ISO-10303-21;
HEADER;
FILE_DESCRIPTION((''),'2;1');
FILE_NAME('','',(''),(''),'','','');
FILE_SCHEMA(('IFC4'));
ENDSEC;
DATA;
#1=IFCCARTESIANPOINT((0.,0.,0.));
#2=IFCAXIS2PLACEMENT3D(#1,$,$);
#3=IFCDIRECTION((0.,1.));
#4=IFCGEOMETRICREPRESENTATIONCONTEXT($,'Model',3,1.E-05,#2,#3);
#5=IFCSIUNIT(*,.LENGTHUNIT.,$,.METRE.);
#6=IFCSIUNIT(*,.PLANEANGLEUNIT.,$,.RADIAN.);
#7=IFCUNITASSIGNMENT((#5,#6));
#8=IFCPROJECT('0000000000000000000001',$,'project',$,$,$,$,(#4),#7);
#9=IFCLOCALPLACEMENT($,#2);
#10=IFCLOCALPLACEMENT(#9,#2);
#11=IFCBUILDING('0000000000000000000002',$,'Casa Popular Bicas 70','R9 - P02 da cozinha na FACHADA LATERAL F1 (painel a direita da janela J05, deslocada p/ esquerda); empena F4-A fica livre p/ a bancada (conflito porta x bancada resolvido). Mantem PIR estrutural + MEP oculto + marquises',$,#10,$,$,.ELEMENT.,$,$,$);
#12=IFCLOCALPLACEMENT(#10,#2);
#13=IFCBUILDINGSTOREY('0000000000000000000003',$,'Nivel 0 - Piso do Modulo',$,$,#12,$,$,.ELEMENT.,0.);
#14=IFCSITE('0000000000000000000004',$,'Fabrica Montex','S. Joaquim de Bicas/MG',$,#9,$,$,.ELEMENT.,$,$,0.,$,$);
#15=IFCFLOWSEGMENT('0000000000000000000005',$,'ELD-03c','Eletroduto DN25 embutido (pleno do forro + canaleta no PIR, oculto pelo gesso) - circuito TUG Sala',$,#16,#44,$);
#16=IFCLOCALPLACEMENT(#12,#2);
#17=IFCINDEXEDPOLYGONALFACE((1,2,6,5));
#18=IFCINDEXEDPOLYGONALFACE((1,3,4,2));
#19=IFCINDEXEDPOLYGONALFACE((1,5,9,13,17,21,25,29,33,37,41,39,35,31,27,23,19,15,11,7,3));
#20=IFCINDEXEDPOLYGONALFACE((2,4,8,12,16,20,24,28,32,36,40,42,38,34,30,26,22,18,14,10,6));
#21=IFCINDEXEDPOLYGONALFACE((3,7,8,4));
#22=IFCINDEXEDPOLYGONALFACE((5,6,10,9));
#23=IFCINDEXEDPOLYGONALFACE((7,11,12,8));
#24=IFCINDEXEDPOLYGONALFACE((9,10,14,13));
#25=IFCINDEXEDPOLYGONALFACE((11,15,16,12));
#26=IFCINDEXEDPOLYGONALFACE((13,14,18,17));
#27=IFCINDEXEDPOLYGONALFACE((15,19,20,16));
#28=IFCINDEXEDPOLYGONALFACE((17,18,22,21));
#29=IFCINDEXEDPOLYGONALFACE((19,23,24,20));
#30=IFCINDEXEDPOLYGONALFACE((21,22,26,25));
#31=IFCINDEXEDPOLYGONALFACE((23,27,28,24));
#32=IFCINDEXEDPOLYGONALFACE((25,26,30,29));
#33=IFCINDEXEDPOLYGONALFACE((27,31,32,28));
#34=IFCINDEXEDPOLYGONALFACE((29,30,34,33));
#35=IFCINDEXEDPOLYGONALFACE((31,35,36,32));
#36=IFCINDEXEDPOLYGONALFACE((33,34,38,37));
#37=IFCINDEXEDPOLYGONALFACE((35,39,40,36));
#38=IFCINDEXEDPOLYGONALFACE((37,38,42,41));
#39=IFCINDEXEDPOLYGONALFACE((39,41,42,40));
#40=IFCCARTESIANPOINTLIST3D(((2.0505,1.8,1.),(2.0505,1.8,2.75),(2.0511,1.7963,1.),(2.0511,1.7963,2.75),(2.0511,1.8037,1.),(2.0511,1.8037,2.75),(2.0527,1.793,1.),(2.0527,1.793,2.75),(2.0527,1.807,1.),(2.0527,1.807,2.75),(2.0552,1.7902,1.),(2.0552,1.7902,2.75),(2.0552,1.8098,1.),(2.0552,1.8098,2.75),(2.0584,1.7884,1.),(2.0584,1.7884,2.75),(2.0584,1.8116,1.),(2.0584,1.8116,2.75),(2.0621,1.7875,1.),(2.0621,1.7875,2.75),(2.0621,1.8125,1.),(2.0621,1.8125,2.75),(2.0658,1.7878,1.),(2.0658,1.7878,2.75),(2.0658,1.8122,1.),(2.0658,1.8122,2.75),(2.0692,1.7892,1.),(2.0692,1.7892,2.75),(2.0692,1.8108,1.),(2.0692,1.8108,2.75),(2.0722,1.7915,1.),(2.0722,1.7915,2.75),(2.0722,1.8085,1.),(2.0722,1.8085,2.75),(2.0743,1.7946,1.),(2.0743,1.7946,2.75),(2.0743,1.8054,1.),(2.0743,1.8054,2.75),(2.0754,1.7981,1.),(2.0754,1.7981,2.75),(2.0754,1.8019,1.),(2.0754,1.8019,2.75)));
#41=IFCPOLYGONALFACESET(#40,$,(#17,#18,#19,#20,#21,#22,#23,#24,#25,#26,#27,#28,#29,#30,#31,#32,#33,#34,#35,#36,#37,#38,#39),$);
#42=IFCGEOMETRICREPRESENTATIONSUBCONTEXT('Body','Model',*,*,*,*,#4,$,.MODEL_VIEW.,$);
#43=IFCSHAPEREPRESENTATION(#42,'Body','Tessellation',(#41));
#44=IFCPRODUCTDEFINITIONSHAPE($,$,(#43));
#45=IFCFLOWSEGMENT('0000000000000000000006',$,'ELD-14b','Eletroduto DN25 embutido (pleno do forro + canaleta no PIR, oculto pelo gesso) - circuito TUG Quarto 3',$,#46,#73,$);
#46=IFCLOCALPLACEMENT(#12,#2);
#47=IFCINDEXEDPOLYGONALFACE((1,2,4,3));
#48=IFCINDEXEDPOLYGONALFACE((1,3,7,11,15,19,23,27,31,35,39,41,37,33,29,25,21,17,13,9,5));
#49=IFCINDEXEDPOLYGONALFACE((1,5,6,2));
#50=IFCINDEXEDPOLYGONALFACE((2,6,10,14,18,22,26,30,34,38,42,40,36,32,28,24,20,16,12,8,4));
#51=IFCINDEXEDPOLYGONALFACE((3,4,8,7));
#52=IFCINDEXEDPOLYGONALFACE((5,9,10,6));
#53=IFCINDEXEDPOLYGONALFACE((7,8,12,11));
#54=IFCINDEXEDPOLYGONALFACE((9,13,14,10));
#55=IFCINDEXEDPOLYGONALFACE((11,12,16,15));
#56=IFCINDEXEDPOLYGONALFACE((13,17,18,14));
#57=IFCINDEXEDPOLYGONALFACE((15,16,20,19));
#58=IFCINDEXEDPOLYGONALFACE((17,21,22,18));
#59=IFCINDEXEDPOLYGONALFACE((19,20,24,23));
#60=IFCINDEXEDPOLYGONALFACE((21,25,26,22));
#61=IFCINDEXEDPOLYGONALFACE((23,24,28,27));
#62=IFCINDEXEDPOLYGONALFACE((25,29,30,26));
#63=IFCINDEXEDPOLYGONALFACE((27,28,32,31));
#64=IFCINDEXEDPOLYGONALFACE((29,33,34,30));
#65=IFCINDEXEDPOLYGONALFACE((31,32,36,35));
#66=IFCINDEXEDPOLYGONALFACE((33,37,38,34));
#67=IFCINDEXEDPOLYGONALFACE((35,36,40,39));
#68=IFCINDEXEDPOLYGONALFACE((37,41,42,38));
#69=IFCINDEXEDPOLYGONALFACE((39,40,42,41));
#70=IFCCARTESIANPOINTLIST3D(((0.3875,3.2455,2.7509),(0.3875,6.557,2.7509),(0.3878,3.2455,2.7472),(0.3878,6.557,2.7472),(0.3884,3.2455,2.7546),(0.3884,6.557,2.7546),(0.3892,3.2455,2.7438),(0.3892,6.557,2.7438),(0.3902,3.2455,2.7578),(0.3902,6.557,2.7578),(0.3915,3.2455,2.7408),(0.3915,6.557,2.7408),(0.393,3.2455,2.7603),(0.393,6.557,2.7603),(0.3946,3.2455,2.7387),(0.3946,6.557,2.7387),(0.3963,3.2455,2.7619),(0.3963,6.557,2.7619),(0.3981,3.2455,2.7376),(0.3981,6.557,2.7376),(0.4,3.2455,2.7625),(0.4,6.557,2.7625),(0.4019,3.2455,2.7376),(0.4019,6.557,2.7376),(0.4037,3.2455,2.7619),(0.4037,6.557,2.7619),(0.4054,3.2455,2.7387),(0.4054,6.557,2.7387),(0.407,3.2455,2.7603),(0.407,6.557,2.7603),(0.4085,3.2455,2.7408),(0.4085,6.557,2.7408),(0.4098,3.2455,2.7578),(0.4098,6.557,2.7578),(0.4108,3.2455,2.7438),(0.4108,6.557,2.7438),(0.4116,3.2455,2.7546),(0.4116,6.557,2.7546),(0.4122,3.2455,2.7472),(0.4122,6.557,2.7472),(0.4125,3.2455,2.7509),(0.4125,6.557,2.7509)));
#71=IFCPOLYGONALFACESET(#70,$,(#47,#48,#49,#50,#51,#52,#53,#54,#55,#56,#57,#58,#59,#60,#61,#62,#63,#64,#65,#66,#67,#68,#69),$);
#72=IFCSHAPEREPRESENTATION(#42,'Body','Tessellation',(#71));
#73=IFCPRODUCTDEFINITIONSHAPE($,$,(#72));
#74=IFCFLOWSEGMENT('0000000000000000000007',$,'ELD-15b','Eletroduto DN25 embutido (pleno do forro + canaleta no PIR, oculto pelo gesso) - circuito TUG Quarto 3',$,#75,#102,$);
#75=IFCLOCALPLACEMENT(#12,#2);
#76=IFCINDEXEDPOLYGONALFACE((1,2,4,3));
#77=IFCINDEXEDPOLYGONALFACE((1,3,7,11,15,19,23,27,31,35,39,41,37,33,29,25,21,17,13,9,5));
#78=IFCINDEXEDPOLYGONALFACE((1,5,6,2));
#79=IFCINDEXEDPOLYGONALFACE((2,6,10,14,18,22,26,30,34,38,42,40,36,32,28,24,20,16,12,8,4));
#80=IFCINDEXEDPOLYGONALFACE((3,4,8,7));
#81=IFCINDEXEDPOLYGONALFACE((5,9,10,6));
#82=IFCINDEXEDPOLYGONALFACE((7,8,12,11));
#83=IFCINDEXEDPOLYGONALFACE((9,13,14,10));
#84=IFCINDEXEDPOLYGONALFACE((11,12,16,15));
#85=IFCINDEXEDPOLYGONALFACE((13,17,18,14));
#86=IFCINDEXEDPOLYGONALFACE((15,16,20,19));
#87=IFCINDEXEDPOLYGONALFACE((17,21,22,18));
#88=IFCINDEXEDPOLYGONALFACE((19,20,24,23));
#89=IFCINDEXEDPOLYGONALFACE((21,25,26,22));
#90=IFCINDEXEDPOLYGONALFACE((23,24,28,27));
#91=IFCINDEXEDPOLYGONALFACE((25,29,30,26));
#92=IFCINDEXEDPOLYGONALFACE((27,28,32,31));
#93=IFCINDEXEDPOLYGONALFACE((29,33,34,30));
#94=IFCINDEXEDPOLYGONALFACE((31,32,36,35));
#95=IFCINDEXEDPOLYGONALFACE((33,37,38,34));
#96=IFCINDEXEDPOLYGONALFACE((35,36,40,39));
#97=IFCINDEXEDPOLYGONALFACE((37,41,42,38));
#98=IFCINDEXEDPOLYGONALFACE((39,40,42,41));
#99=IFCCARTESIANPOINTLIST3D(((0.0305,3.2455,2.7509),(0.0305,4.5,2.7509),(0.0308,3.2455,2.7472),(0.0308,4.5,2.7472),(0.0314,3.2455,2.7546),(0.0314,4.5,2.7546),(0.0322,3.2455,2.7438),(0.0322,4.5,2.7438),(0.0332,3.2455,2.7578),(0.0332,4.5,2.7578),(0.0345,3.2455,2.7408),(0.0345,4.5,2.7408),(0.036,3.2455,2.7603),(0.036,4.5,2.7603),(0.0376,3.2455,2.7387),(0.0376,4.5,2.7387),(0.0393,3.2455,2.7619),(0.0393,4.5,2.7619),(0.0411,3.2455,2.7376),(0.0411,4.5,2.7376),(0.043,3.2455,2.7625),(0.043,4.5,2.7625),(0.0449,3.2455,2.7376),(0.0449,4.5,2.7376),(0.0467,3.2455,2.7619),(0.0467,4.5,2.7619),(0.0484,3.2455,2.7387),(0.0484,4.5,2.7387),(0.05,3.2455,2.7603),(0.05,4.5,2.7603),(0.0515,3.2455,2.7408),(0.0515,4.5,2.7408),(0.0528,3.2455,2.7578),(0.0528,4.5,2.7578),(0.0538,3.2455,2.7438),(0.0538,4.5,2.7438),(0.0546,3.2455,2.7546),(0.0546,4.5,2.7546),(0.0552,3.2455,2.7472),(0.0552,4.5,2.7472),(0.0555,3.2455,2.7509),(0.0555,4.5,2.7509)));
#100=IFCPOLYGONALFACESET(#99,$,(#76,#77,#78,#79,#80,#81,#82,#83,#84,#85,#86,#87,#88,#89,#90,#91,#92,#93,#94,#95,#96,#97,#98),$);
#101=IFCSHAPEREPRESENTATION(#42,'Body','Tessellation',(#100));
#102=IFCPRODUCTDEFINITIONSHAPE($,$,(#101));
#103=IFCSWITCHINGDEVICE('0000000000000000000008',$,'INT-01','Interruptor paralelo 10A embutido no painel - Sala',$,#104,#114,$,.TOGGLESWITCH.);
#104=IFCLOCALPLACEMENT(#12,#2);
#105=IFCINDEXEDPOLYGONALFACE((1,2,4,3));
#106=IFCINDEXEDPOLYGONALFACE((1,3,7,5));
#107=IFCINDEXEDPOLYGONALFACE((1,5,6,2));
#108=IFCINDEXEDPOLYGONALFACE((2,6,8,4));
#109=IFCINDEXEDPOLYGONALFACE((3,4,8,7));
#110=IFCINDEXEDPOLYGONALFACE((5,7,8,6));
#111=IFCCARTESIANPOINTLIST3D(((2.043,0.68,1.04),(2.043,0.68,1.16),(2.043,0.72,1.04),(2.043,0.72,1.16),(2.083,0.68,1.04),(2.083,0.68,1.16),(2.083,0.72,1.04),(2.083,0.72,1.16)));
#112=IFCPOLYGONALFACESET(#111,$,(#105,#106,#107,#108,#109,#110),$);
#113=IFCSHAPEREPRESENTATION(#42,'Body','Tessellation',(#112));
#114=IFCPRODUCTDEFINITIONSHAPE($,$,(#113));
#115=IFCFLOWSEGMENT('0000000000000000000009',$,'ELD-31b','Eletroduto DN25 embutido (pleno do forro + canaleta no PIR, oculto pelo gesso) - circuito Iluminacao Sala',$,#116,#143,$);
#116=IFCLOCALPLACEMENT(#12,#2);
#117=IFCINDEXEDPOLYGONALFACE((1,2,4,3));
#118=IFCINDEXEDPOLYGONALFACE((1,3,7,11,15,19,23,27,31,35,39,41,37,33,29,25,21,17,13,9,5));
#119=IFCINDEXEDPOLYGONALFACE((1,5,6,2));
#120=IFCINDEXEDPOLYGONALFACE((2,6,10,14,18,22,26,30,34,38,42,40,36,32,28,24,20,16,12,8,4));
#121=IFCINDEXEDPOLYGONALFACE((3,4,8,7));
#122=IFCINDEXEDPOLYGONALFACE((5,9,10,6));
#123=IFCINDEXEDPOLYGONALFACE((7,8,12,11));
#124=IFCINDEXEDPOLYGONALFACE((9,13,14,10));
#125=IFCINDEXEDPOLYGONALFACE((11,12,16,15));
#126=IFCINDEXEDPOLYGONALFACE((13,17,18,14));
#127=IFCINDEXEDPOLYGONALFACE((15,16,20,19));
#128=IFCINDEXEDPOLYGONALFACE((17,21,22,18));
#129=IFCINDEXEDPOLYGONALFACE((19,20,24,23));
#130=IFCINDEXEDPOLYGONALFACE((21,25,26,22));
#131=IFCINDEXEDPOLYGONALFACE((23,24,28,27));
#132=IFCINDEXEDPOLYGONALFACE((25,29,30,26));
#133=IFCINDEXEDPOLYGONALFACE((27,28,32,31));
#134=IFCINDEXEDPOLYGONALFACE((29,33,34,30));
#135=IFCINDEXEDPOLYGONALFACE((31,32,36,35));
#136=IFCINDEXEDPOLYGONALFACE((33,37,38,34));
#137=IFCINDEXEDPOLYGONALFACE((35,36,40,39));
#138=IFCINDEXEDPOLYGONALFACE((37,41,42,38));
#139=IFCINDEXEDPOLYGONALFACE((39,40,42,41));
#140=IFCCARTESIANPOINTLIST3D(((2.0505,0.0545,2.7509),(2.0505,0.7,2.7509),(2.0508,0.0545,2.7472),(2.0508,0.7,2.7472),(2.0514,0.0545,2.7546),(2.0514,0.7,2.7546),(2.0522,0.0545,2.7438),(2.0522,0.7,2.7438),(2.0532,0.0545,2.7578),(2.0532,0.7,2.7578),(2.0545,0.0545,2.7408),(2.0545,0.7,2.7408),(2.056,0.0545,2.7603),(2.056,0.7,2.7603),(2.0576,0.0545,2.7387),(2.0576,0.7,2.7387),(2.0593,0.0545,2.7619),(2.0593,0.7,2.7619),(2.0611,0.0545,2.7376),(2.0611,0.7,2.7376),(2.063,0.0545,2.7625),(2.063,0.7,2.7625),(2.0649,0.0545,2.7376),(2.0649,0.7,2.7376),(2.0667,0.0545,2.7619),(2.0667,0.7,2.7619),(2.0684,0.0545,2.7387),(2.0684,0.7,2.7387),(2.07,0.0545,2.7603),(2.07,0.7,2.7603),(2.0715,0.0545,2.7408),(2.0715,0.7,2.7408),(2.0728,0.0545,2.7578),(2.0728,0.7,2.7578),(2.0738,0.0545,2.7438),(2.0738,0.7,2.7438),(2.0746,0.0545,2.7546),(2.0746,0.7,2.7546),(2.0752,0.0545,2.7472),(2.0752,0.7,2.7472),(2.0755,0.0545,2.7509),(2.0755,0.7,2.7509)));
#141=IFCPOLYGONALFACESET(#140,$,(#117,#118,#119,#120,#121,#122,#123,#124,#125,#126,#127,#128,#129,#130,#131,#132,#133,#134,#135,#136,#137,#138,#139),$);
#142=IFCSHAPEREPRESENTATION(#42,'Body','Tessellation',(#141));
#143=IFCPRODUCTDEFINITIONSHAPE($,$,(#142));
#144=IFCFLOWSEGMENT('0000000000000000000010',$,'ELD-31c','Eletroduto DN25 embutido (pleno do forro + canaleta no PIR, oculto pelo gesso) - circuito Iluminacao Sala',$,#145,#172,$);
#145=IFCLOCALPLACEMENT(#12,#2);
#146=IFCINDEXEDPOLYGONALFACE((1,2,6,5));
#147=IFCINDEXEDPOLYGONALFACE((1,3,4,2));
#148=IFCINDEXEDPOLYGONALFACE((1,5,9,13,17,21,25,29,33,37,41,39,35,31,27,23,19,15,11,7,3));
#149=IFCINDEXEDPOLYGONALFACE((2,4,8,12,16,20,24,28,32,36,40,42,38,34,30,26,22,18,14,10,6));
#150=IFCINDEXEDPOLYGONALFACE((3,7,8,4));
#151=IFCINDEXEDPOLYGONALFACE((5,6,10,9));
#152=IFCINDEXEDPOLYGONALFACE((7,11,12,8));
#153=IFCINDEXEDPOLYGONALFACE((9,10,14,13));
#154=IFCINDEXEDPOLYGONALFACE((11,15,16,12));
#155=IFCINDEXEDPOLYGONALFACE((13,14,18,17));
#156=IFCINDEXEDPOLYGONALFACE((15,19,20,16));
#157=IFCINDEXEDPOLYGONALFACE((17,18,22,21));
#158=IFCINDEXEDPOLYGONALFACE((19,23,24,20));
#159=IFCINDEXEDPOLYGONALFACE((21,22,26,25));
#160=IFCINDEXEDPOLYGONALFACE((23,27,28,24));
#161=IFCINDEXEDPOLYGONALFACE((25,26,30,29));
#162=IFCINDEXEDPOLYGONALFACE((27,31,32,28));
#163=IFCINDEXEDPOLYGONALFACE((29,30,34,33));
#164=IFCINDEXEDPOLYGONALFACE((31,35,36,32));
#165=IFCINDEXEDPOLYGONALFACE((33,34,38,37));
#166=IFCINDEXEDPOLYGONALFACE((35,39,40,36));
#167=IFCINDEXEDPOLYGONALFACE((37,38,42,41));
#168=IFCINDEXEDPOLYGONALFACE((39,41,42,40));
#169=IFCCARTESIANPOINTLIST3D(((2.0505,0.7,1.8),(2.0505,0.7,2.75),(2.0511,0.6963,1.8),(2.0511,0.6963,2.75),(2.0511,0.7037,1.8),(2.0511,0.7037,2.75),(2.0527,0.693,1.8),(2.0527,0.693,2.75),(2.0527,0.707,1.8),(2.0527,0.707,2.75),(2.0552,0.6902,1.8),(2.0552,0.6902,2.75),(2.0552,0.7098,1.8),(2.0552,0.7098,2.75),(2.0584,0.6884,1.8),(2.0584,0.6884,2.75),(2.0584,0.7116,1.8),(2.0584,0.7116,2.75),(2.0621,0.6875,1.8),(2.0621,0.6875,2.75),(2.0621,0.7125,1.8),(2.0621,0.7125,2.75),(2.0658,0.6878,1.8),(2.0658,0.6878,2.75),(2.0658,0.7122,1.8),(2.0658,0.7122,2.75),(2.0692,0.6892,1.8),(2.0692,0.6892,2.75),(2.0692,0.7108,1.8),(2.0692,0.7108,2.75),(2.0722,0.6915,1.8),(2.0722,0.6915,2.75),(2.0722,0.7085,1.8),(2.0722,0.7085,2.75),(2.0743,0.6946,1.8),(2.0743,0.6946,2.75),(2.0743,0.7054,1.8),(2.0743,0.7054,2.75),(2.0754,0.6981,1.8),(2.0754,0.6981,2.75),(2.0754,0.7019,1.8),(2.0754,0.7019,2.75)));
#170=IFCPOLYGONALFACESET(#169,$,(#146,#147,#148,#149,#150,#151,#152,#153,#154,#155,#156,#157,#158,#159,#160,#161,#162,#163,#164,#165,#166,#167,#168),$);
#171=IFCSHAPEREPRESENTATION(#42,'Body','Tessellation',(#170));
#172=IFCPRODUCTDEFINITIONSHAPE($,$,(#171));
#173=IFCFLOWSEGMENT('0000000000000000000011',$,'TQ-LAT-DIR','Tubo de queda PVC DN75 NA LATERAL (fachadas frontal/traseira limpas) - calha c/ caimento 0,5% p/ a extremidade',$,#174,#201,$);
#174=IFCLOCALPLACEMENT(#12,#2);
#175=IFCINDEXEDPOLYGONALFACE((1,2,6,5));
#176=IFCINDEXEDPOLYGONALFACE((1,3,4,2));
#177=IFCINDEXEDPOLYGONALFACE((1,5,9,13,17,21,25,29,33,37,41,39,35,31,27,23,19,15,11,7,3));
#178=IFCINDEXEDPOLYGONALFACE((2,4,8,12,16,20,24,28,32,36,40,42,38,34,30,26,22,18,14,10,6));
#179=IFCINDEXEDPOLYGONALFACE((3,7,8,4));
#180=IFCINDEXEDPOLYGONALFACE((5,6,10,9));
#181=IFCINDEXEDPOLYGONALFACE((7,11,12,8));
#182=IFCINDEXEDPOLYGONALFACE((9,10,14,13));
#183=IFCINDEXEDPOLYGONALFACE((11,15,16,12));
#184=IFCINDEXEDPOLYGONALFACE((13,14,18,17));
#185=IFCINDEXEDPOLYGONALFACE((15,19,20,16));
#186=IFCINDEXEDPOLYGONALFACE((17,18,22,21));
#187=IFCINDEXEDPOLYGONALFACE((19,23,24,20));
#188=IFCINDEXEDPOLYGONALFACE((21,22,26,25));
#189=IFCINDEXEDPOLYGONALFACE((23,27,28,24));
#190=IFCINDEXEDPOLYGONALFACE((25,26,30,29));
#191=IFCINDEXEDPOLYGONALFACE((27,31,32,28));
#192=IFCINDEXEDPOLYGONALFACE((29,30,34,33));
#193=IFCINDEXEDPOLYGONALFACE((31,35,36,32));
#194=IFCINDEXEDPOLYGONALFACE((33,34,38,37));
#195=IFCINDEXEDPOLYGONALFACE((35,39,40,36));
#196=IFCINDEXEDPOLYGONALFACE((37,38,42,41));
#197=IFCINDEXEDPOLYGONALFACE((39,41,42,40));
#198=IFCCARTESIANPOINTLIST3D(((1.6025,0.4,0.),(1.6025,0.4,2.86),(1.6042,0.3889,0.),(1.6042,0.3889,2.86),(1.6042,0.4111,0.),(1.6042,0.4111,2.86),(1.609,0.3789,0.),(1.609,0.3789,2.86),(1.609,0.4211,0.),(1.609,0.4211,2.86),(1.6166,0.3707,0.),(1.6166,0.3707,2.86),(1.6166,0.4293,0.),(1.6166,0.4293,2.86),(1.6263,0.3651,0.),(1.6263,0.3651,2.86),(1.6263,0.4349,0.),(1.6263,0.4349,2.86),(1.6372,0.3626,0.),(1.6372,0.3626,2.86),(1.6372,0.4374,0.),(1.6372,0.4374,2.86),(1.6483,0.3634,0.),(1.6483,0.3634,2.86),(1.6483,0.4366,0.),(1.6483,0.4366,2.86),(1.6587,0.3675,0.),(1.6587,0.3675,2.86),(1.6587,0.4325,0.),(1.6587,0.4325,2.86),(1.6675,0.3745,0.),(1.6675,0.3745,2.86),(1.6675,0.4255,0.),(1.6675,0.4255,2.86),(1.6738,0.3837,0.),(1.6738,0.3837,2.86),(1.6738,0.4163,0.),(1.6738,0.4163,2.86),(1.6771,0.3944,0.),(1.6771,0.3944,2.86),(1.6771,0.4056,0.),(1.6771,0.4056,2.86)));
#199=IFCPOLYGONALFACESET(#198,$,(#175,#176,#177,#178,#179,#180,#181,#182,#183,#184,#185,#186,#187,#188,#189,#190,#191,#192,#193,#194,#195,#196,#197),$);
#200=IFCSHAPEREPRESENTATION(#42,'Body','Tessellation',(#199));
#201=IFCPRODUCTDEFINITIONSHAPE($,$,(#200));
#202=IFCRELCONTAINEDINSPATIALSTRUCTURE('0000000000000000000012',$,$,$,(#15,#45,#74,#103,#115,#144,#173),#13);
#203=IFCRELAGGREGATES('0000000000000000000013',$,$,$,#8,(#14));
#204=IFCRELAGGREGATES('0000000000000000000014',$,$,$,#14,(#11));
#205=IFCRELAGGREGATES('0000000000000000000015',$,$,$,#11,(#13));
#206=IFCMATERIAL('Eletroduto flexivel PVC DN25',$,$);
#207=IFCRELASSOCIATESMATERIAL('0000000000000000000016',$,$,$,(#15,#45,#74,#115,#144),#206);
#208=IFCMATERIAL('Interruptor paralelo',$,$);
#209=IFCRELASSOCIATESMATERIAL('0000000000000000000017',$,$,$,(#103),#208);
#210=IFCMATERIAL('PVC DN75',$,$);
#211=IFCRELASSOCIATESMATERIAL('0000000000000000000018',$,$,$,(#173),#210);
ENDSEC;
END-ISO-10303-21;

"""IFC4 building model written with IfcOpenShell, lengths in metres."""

from ifc_helpers import new_model, si_unit, direction, frame, frame_2d, origin, origin_2d, place, context, subcontext, project, spatial, rectangle, circle, extrude, material, element, save


model = new_model("IFC4")

# Units and contexts
model_context = context("Model", 3, precision=1e-05, world=origin(), true_north=direction((0.0, 1.0)))
body_context = subcontext(model_context, "Body", "Model", "MODEL_VIEW")
ifc_project = project(units=[si_unit("LENGTHUNIT", "METRE"), si_unit("PLANEANGLEUNIT", "RADIAN")], contexts=[model_context])

# Site, building, storey
site_placement = place(None, origin())
site = spatial("IfcSite", under=ifc_project, at=site_placement, Name="Fabrica Montex", Description="S. Joaquim de Bicas/MG", CompositionType="ELEMENT", RefElevation=0.0)
building_placement = place(site_placement, origin())
building = spatial("IfcBuilding", under=site, at=building_placement, Name="Casa Popular Bicas 70", Description="R9 - P02 da cozinha na FACHADA LATERAL F1 (painel a direita da janela J05, deslocada p/ esquerda); empena F4-A fica livre p/ a bancada (conflito porta x bancada resolvido). Mantem PIR estrutural + MEP oculto + marquises", CompositionType="ELEMENT")
storey_placement = place(building_placement, origin())
storey = spatial("IfcBuildingStorey", under=building, at=storey_placement, Name="Nivel 0 - Piso do Modulo", CompositionType="ELEMENT", Elevation=0.0)

# Flow segments
ifc_material_1 = material(Name="Eletroduto flexivel PVC DN25")
flow_segment_1_placement = place(None, frame((2.063, 1.8, 2.75), z_axis=(0.0, 0.0, -1.0), x_axis=(-1.0, 0.0, 0.0)))
element("IfcFlowSegment", 1, at=flow_segment_1_placement, inside=storey, material=ifc_material_1, Name="ELD-03c", Description="Eletroduto DN25 embutido (pleno do forro + canaleta no PIR, oculto pelo gesso) - circuito TUG Sala", context=body_context, shape_type="SweptSolid", body=[
    extrude(circle(Radius=0.0125, at=origin_2d()), origin(), (0.0, 0.0, 1.0), 1.75),
])
flow_segment_2_placement = place(storey_placement, frame((0.4, 3.2455, 2.75), z_axis=(0.0, 1.0, 0.0), x_axis=(0.0, 0.0, 1.0)))
element("IfcFlowSegment", 2, at=flow_segment_2_placement, inside=storey, material=ifc_material_1, Name="ELD-14b", Description="Eletroduto DN25 embutido (pleno do forro + canaleta no PIR, oculto pelo gesso) - circuito TUG Quarto 3", context=body_context, shape_type="SweptSolid", body=[
    extrude(circle(Radius=0.0125, at=origin_2d()), origin(), (0.0, 0.0, 1.0), 3.3115),
])
flow_segment_3_placement = place(storey_placement, frame((0.043, 3.2455, 2.75), z_axis=(0.0, 1.0, 0.0), x_axis=(0.0, 0.0, 1.0)))
element("IfcFlowSegment", 3, at=flow_segment_3_placement, inside=storey, material=ifc_material_1, Name="ELD-15b", Description="Eletroduto DN25 embutido (pleno do forro + canaleta no PIR, oculto pelo gesso) - circuito TUG Quarto 3", context=body_context, shape_type="SweptSolid", body=[
    extrude(circle(Radius=0.0125, at=origin_2d()), origin(), (0.0, 0.0, 1.0), 1.2545),
])

# Switching device
ifc_material_2 = material(Name="Interruptor paralelo")
switching_device_placement = place(None, frame((2.083, 0.72, 1.04), z_axis=(0.0, 0.0, 1.0), x_axis=(-1.0, 0.0, 0.0)))
element("IfcSwitchingDevice", 4, at=switching_device_placement, inside=storey, material=ifc_material_2, Name="INT-01", Description="Interruptor paralelo 10A embutido no painel - Sala", PredefinedType="TOGGLESWITCH", context=body_context, shape_type="SweptSolid", body=[
    extrude(rectangle(XDim=0.04, YDim=0.04, at=frame_2d((0.02, 0.02))), origin(), (0.0, 0.0, 1.0), 0.12),
])

# Flow segments
flow_segment_4_placement = place(None, frame((2.063, 0.0545, 2.75), z_axis=(0.0, 1.0, 0.0), x_axis=(0.0, 0.0, 1.0)))
element("IfcFlowSegment", 5, at=flow_segment_4_placement, inside=storey, material=ifc_material_1, Name="ELD-31b", Description="Eletroduto DN25 embutido (pleno do forro + canaleta no PIR, oculto pelo gesso) - circuito Iluminacao Sala", context=body_context, shape_type="SweptSolid", body=[
    extrude(circle(Radius=0.0125, at=origin_2d()), origin(), (0.0, 0.0, 1.0), 0.6455),
])
flow_segment_5_placement = place(None, frame((2.063, 0.7, 2.75), z_axis=(0.0, 0.0, -1.0), x_axis=(-1.0, 0.0, 0.0)))
element("IfcFlowSegment", 6, at=flow_segment_5_placement, inside=storey, material=ifc_material_1, Name="ELD-31c", Description="Eletroduto DN25 embutido (pleno do forro + canaleta no PIR, oculto pelo gesso) - circuito Iluminacao Sala", context=body_context, shape_type="SweptSolid", body=[
    extrude(circle(Radius=0.0125, at=origin_2d()), origin(), (0.0, 0.0, 1.0), 0.95),
])
ifc_material_3 = material(Name="PVC DN75")
flow_segment_6_placement = place(None, frame((1.64, 0.4, 0.0), z_axis=(0.0, 0.0, 1.0), x_axis=(-1.0, 0.0, 0.0)))
element("IfcFlowSegment", 7, at=flow_segment_6_placement, inside=storey, material=ifc_material_3, Name="TQ-LAT-DIR", Description="Tubo de queda PVC DN75 NA LATERAL (fachadas frontal/traseira limpas) - calha c/ caimento 0,5% p/ a extremidade", context=body_context, shape_type="SweptSolid", body=[
    extrude(circle(Radius=0.0375, at=origin_2d()), origin(), (0.0, 0.0, 1.0), 2.86),
])

save(model, "model.ifc")
